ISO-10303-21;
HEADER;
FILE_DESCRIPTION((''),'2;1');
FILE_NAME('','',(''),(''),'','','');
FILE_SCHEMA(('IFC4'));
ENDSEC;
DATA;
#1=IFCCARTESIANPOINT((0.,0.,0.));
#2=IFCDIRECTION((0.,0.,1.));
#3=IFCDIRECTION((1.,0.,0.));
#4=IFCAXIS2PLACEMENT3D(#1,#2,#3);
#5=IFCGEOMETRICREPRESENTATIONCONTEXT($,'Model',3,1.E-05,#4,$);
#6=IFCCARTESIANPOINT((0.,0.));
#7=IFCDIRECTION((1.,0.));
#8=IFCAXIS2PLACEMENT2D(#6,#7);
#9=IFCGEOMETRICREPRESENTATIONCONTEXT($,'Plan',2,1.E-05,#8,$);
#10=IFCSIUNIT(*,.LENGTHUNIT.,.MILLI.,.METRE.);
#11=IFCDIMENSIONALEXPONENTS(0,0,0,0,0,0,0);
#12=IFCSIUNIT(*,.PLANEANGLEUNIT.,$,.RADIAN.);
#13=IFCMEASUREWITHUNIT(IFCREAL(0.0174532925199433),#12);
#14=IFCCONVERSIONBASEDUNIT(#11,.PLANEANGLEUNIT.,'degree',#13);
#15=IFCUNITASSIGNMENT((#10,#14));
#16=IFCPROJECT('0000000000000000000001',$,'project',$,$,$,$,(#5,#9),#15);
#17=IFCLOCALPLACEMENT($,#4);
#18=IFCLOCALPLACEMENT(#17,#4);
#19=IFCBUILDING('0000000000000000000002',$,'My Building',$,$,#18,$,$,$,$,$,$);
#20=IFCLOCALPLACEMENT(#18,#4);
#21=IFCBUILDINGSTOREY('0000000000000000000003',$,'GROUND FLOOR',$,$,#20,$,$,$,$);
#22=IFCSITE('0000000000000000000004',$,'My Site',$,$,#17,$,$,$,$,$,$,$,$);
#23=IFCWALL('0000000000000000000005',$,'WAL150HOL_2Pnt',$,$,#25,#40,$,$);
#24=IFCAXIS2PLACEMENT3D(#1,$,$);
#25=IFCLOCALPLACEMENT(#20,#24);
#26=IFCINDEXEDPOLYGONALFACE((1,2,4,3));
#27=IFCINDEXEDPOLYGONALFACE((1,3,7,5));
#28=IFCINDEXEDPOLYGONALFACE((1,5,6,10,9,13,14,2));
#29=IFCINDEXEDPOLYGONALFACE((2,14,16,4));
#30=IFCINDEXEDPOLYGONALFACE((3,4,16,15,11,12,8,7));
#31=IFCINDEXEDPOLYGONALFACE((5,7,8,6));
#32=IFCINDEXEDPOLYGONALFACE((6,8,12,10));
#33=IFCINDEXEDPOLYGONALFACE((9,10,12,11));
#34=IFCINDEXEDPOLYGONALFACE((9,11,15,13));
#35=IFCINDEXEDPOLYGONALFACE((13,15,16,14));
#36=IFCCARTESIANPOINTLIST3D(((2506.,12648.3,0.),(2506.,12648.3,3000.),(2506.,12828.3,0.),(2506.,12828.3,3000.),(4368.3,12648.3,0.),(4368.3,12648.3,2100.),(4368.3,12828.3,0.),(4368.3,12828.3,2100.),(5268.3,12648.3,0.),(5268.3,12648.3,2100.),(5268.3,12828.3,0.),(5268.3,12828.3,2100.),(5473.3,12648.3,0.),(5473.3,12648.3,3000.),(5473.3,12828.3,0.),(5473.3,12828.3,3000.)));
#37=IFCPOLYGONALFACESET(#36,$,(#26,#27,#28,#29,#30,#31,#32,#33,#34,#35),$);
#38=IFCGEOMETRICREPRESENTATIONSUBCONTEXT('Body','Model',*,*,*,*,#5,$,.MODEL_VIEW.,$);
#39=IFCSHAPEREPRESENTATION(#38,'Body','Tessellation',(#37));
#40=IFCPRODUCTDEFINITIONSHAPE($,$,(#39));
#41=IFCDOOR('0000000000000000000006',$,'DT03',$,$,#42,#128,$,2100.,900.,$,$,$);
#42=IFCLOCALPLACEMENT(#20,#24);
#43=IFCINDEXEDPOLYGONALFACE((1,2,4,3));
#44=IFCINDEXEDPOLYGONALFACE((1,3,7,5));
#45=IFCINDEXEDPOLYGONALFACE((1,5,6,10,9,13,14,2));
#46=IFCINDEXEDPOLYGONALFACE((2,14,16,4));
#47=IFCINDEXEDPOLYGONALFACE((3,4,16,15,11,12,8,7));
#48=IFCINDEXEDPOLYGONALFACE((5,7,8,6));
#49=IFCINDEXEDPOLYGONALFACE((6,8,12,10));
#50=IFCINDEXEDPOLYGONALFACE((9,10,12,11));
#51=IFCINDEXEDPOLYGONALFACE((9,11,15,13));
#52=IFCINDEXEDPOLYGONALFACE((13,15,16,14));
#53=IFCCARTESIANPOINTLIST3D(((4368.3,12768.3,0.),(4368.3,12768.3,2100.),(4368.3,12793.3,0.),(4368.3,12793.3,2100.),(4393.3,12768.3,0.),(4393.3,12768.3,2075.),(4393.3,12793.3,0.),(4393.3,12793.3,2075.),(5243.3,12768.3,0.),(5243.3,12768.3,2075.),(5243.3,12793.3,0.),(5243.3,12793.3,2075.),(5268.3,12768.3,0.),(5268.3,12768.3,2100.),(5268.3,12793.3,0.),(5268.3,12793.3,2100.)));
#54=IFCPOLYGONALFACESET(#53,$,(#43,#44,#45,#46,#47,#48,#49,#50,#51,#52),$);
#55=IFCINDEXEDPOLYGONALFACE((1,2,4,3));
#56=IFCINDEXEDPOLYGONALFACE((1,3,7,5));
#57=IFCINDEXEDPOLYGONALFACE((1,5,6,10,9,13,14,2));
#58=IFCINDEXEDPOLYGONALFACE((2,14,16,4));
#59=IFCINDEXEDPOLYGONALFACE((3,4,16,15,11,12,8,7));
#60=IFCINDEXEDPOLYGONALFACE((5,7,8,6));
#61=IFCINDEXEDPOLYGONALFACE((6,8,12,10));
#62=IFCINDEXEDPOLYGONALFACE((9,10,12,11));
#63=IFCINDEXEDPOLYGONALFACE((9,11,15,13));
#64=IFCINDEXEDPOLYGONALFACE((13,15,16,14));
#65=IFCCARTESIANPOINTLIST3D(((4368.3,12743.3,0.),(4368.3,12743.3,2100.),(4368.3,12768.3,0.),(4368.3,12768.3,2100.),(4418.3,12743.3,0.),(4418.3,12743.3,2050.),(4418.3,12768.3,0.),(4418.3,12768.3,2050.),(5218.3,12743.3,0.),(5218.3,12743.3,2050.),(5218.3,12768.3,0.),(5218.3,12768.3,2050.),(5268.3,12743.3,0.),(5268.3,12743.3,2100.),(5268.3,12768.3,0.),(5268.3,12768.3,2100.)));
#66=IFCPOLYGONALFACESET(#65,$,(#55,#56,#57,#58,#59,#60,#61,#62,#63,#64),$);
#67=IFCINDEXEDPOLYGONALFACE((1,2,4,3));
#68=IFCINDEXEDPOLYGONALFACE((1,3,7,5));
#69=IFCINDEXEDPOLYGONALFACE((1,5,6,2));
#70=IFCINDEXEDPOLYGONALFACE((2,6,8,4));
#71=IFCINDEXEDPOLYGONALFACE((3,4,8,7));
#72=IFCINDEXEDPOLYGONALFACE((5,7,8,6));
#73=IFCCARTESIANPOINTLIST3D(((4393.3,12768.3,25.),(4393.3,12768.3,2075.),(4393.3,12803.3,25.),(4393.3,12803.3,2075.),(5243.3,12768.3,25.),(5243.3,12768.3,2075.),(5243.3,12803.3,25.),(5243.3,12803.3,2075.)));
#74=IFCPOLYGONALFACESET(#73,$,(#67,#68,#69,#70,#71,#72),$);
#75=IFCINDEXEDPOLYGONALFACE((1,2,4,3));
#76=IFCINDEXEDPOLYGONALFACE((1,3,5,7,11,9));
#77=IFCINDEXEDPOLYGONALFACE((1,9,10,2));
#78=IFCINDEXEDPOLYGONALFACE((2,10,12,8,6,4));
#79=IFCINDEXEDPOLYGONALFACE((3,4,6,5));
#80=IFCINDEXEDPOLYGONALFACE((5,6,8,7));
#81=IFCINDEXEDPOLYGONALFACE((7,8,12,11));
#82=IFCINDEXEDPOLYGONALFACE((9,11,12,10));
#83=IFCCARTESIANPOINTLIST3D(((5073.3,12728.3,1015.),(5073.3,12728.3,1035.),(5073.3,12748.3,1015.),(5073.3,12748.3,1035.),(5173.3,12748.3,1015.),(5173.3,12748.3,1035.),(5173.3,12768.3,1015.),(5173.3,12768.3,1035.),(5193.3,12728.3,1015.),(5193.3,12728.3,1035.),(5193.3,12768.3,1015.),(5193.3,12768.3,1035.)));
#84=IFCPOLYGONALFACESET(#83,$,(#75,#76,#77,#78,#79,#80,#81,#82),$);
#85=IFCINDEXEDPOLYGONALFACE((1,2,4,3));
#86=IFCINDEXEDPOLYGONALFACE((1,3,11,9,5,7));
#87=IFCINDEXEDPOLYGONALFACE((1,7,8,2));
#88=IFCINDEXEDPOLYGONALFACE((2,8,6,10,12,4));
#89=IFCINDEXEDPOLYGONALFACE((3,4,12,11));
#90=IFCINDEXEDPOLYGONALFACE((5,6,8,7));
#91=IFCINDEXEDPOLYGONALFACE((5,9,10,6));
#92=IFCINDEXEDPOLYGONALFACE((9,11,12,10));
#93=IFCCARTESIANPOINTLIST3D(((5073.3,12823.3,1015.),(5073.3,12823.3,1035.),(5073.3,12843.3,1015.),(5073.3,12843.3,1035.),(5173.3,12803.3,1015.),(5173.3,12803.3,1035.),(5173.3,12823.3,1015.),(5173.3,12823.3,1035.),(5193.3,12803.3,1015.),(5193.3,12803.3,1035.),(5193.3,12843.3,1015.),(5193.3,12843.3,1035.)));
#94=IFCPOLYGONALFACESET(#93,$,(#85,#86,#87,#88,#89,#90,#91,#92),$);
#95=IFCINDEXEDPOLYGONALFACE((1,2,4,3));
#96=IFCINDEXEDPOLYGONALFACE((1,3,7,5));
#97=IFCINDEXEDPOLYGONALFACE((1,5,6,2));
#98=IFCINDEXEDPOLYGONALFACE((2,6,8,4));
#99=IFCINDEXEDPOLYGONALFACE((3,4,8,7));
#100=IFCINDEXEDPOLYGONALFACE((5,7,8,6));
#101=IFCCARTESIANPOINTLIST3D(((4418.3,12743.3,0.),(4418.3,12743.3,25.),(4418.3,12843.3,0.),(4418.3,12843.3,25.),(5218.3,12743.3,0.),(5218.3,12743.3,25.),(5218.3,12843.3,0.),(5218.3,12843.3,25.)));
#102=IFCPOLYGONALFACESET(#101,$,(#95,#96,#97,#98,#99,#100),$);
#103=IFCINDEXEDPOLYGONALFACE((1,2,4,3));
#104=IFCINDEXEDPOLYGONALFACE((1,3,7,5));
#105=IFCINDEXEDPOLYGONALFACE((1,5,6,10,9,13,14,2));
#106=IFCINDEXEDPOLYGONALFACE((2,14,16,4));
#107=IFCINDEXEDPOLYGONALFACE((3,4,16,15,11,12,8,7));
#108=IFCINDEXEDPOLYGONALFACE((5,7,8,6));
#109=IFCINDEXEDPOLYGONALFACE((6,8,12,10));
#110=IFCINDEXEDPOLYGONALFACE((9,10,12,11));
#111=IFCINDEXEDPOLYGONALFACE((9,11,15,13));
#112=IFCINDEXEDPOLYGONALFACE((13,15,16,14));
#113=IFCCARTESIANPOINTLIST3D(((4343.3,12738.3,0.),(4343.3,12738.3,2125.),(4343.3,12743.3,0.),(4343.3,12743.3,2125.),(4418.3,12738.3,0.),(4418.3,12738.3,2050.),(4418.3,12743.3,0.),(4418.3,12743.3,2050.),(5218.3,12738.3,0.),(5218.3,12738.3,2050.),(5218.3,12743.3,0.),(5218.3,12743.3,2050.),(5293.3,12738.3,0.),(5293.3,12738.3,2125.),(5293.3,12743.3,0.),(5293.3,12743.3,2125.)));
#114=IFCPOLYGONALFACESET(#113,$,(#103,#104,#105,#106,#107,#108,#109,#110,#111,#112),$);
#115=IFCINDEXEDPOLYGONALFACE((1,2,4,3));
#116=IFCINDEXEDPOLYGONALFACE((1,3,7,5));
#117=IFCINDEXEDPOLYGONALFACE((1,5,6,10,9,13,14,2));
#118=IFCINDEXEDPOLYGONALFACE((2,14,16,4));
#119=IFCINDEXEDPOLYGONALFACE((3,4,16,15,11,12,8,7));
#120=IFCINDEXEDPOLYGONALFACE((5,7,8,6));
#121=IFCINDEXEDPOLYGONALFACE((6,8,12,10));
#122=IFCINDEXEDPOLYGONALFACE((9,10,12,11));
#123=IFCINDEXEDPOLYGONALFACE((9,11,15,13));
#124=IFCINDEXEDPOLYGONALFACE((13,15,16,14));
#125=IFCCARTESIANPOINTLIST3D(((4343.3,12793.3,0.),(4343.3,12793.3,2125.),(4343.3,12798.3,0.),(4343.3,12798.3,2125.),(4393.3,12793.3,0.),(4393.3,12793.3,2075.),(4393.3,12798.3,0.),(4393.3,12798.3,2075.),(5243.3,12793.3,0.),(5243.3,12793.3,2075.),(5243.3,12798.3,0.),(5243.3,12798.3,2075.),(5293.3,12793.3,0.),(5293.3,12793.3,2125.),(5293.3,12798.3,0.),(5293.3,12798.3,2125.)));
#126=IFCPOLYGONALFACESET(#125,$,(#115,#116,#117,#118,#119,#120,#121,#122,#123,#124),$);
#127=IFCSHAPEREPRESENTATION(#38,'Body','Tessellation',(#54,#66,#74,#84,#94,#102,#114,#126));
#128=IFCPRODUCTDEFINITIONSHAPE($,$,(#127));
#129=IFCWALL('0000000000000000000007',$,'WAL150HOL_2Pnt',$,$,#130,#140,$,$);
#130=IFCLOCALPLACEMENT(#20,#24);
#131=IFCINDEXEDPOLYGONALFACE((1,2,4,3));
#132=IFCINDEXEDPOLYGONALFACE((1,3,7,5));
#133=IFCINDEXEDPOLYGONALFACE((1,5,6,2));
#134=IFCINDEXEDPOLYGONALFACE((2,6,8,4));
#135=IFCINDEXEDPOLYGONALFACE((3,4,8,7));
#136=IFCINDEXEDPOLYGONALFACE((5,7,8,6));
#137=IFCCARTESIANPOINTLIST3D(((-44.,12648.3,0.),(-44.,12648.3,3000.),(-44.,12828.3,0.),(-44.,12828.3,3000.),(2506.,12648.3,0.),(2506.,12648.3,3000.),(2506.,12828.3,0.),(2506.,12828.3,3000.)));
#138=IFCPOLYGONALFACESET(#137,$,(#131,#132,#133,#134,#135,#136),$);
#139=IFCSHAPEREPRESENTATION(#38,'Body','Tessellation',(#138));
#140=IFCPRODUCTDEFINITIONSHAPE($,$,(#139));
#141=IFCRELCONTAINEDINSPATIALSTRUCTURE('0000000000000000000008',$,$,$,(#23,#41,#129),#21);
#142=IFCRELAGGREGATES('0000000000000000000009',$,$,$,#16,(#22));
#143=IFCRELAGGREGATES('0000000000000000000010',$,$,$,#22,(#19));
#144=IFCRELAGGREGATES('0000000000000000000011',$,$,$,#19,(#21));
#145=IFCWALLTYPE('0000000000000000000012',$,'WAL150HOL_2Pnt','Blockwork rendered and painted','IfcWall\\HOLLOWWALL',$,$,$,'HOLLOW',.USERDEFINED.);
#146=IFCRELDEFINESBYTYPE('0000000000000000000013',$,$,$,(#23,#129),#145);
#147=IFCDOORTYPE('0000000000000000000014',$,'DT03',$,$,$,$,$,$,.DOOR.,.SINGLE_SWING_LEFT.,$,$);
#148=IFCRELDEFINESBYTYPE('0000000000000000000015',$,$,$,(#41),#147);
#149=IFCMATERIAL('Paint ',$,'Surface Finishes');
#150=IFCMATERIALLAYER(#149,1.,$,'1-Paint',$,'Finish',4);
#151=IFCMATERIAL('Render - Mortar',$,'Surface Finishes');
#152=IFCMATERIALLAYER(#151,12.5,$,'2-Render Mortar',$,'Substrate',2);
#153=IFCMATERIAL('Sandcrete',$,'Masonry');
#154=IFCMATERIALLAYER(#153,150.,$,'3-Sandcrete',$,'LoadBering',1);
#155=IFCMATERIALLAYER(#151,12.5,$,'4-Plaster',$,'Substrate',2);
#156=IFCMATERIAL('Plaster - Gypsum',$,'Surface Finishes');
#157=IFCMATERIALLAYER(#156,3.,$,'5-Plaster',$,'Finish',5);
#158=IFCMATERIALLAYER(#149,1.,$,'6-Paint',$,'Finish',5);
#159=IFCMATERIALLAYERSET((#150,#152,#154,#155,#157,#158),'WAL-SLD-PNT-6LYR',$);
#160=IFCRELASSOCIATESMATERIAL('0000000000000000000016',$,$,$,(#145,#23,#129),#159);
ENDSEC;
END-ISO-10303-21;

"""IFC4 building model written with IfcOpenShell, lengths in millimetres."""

from ifc_helpers import new_model, entity, si_unit, converted_unit, frame, origin_with_axes, origin_2d_with_axis, place, context, subcontext, project, spatial, line, indexed_curve, outline, extrude, shape, source, transform, mapped, material, layer, layer_set, layer_usage, type_object, type_shapes, element, fill, save


model = new_model("IFC4")

# Units and contexts
model_context = context("Model", 3, precision=1e-05, world=origin_with_axes())
plan_context = context("Plan", 2, precision=1e-05, world=origin_2d_with_axis())
body_context_1 = subcontext(model_context, "Body", "Model", "MODEL_VIEW")
body_context_2 = subcontext(plan_context, "Body", "Plan", "PLAN_VIEW")
ifc_project = project(units=[si_unit("LENGTHUNIT", "METRE", prefix="MILLI"), converted_unit("PLANEANGLEUNIT", "degree", entity("IfcReal", 0.0174532925199433), si_unit("PLANEANGLEUNIT", "RADIAN"), dimensions=[0, 0, 0, 0, 0, 0, 0])], contexts=[model_context, plan_context])

# Site, building, storey
site_placement = place(None, origin_with_axes())
site = spatial("IfcSite", under=ifc_project, at=site_placement, Name="My Site")
building_placement = place(site_placement, origin_with_axes())
building = spatial("IfcBuilding", under=site, at=building_placement, Name="My Building")
storey_placement = place(building_placement, origin_with_axes())
storey = spatial("IfcBuildingStorey", under=building, at=storey_placement, Name="GROUND FLOOR")

# Shared definitions
ifc_material_1 = material(Name="Paint ", Category="Surface Finishes")
ifc_layer_1 = layer(ifc_material_1, 1.0, Name="1-Paint", Category="Finish", Priority=4)
ifc_material_2 = material(Name="Render - Mortar", Category="Surface Finishes")
ifc_layer_2 = layer(ifc_material_2, 12.5, Name="2-Render Mortar", Category="Substrate", Priority=2)
ifc_material_3 = material(Name="Sandcrete", Category="Masonry")
ifc_layer_3 = layer(ifc_material_3, 150.0, Name="3-Sandcrete", Category="LoadBering", Priority=1)
ifc_layer_4 = layer(ifc_material_2, 12.5, Name="4-Plaster", Category="Substrate", Priority=2)
ifc_material_4 = material(Name="Plaster - Gypsum", Category="Surface Finishes")
ifc_layer_5 = layer(ifc_material_4, 3.0, Name="5-Plaster", Category="Finish", Priority=5)
ifc_layer_6 = layer(ifc_material_1, 1.0, Name="6-Paint", Category="Finish", Priority=5)
ifc_layer_set_1 = layer_set([ifc_layer_1, ifc_layer_2, ifc_layer_3, ifc_layer_4, ifc_layer_5, ifc_layer_6], Name="WAL-SLD-PNT-6LYR")
wall_type_1 = type_object("IfcWallType", Name="WAL150HOL_2Pnt", Description="Blockwork rendered and painted", ApplicableOccurrence="IfcWall\\HOLLOWWALL", ElementType="HOLLOW", PredefinedType="USERDEFINED", material=ifc_layer_set_1)

# Shared definitions
shared_shape_1 = source(origin_with_axes(), body_context_1, "Body", "SweptSolid", [
    extrude(outline(indexed_curve([(0.0, 0.0), (900.0, 0.0), (900.0, 2100.0), (0.0, 2100.0)], segments=[line(1, 2, 3, 4, 1)])), frame((0.0, -100.0, 0.0), z_axis=(0.0, -1.0, 0.0), x_axis=(1.0, 0.0, 0.0)), (0.0, 0.0, -1.0), 380.0),
])
door_type_1 = type_object("IfcDoorType", Name="DT03", OperationType="SINGLE_SWING_LEFT", PredefinedType="DOOR")
shared_shape_2 = source(origin_with_axes(), body_context_1, "Body", "SweptSolid", [
    extrude(outline(indexed_curve([(0.0, 0.0), (0.0, 2100.0), (900.0, 2100.0), (900.0, 0.0), (875.0, 0.0), (875.0, 2075.0), (25.0, 2075.0), (25.0, 0.0)], segments=[line(1, 2, 3, 4, 5, 6, 7, 8, 1)])), frame((0.0, 25.0, 0.0), z_axis=(0.0, -1.0, 0.0), x_axis=(1.0, 0.0, 0.0)), (0.0, 0.0, -1.0), 25.0),
    extrude(outline(indexed_curve([(0.0, 0.0), (0.0, 2100.0), (900.0, 2100.0), (900.0, 0.0), (850.0, 0.0), (850.0, 2050.0), (50.0, 2050.0), (50.0, 0.0)], segments=[line(1, 2, 3, 4, 5, 6, 7, 8, 1)])), frame((0.0, 0.0, 0.0), z_axis=(0.0, -1.0, 0.0), x_axis=(1.0, 0.0, 0.0)), (0.0, 0.0, -1.0), 25.0),
    extrude(outline(indexed_curve([(0.0, 0.0), (850.0, 0.0), (850.0, 35.0), (0.0, 35.0)], segments=[line(1, 2, 3, 4, 1)])), frame((25.0, 25.0, 25.0), z_axis=(0.0, 0.0, 1.0), x_axis=(1.0, 0.0, 0.0)), (0.0, 0.0, 1.0), 2050.0),
    extrude(outline(indexed_curve([(0.0, 0.0), (0.0, -40.0), (-120.0, -40.0), (-120.0, -20.0), (-20.0, -20.0), (-20.0, 0.0)], segments=[line(1, 2, 3, 4, 5, 6, 1)])), frame((825.0, 25.0, 1015.0), z_axis=(0.0, 0.0, 1.0), x_axis=(1.0, 0.0, 0.0)), (0.0, 0.0, 1.0), 20.0),
    extrude(outline(indexed_curve([(0.0, 0.0), (0.0, 40.0), (-120.0, 40.0), (-120.0, 20.0), (-20.0, 20.0), (-20.0, 0.0)], segments=[line(1, 2, 3, 4, 5, 6, 1)])), frame((825.0, 60.0, 1015.0), z_axis=(0.0, 0.0, 1.0), x_axis=(1.0, 0.0, 0.0)), (0.0, 0.0, 1.0), 20.0),
    extrude(outline(indexed_curve([(0.0, 0.0), (800.0, 0.0), (800.0, 100.0), (0.0, 100.0)], segments=[line(1, 2, 3, 4, 1)])), frame((50.0, 0.0, 0.0), z_axis=(0.0, 0.0, 1.0), x_axis=(1.0, 0.0, 0.0)), (0.0, 0.0, 1.0), 25.0),
    extrude(outline(indexed_curve([(0.0, 0.0), (0.0, 2125.0), (950.0, 2125.0), (950.0, 0.0), (875.0, 0.0), (875.0, 2050.0), (75.0, 2050.0), (75.0, 0.0)], segments=[line(1, 2, 3, 4, 5, 6, 7, 8, 1)])), frame((-25.0, -5.0, 0.0), z_axis=(0.0, -1.0, 0.0), x_axis=(1.0, 0.0, 0.0)), (0.0, 0.0, -1.0), 5.0),
    extrude(outline(indexed_curve([(0.0, 0.0), (0.0, 2125.0), (950.0, 2125.0), (950.0, 0.0), (900.0, 0.0), (900.0, 2075.0), (50.0, 2075.0), (50.0, 0.0)], segments=[line(1, 2, 3, 4, 5, 6, 7, 8, 1)])), frame((-25.0, 50.0, 0.0), z_axis=(0.0, -1.0, 0.0), x_axis=(1.0, 0.0, 0.0)), (0.0, 0.0, -1.0), 5.0),
])
shared_shape_3 = source(origin_with_axes(), body_context_2, "Body", "Curve2D", [
    entity("IfcIndexedPolyCurve", entity("IfcCartesianPointList2D", [[0.0, 0.0], [0.0, 50.0], [25.0, 50.0], [25.0, 25.0], [50.0, 25.0], [50.0, 0.0]]), [entity("IfcLineIndex", [1, 2, 3, 4, 5, 6, 1])]),
    entity("IfcIndexedPolyCurve", entity("IfcCartesianPointList2D", [[900.0, 0.0], [900.0, 50.0], [875.0, 50.0], [875.0, 25.0], [850.0, 25.0], [850.0, 0.0]]), [entity("IfcLineIndex", [1, 2, 3, 4, 5, 6, 1])]),
    entity("IfcTrimmedCurve", entity("IfcEllipse", entity("IfcAxis2Placement2D", entity("IfcCartesianPoint", [60.0, 50.0]), entity("IfcDirection", [1.0, 0.0])), 815.0, 850.0), [entity("IfcCartesianPoint", [875.0, 50.0])], [entity("IfcCartesianPoint", [60.0, 900.0])], True, "CARTESIAN"),
    entity("IfcIndexedPolyCurve", entity("IfcCartesianPointList2D", [[25.0, 50.0], [60.0, 50.0], [60.0, 900.0], [25.0, 900.0]]), [entity("IfcLineIndex", [1, 2, 3, 4, 1])]),
])
type_shapes(door_type_1, [shared_shape_2, shared_shape_3])

# Wall, opening, door
ifc_layer_usage_1 = layer_usage(ifc_layer_set_1, "AXIS2", "POSITIVE", 0.0)
wall_1_placement = place(storey_placement, frame((5473.3, 12828.3, 0.0), z_axis=(0.0, 0.0, 1.0), x_axis=(-1.0, 0.0, 0.0)))
wall_1 = element("IfcWall", 1, at=wall_1_placement, inside=storey, type_object=wall_type_1, material=ifc_layer_usage_1, Name="WAL150HOL_2Pnt", context=body_context_1, shape_type="SweptSolid", body=[
    extrude(outline(indexed_curve([(0.0, 0.0), (0.0, 180.0), (2967.3, 180.0), (2967.3, 0.0), (0.0, 0.0)], self_intersect=False)), origin_with_axes(), (0.0, 0.0, 1.0), 3000.0),
])
opening_1_placement = place(wall_1_placement, frame((1105.0, 85.0, 0.0), z_axis=(0.0, 0.0, 1.0), x_axis=(-1.0, 0.0, 0.0)))
opening_1 = element("IfcOpeningElement", 2, at=opening_1_placement, cuts=wall_1, PredefinedType="OPENING", context=body_context_1, shape_type="MappedRepresentation", body=[
    mapped(shared_shape_1, transform((0.0, 0.0, 0.0), x_axis=(1.0, 0.0, 0.0), y_axis=(0.0, 1.0, 0.0), z_axis=(0.0, 0.0, 1.0), scale=1.0)),
])
door_1_placement = place(opening_1_placement, frame((0.0, 0.0, 0.0), z_axis=(0.0, 0.0, 1.0), x_axis=(1.0, 0.0, 0.0)))
door_1 = element("IfcDoor", 3, at=door_1_placement, inside=storey, type_object=door_type_1, Name="DT03", OverallHeight=2100.0, OverallWidth=900.0, shapes=[
    shape(body_context_1, "Body", "MappedRepresentation", [mapped(shared_shape_2, transform((0.0, 0.0, 0.0), x_axis=(1.0, 0.0, 0.0), y_axis=(0.0, 1.0, 0.0), z_axis=(0.0, 0.0, 1.0), scale=1.0))]),
    shape(body_context_2, "Body", "MappedRepresentation", [mapped(shared_shape_3, transform((0.0, 0.0, 0.0), x_axis=(1.0, 0.0, 0.0), y_axis=(0.0, 1.0, 0.0), z_axis=(0.0, 0.0, 1.0), scale=1.0))]),
])
fill(opening_1, door_1)

# Wall
ifc_layer_usage_2 = layer_usage(ifc_layer_set_1, "AXIS2", "POSITIVE", 0.0)
wall_2_placement = place(storey_placement, frame((2506.0, 12828.3, 0.0), z_axis=(0.0, 0.0, 1.0), x_axis=(-1.0, 0.0, 0.0)))
element("IfcWall", 4, at=wall_2_placement, inside=storey, type_object=wall_type_1, material=ifc_layer_usage_2, Name="WAL150HOL_2Pnt", context=body_context_1, shape_type="SweptSolid", body=[
    extrude(outline(indexed_curve([(0.0, 0.0), (0.0, 180.0), (2550.0, 180.0), (2550.0, 0.0), (0.0, 0.0)], self_intersect=False)), origin_with_axes(), (0.0, 0.0, 1.0), 3000.0),
])

save(model, "model.ifc")
